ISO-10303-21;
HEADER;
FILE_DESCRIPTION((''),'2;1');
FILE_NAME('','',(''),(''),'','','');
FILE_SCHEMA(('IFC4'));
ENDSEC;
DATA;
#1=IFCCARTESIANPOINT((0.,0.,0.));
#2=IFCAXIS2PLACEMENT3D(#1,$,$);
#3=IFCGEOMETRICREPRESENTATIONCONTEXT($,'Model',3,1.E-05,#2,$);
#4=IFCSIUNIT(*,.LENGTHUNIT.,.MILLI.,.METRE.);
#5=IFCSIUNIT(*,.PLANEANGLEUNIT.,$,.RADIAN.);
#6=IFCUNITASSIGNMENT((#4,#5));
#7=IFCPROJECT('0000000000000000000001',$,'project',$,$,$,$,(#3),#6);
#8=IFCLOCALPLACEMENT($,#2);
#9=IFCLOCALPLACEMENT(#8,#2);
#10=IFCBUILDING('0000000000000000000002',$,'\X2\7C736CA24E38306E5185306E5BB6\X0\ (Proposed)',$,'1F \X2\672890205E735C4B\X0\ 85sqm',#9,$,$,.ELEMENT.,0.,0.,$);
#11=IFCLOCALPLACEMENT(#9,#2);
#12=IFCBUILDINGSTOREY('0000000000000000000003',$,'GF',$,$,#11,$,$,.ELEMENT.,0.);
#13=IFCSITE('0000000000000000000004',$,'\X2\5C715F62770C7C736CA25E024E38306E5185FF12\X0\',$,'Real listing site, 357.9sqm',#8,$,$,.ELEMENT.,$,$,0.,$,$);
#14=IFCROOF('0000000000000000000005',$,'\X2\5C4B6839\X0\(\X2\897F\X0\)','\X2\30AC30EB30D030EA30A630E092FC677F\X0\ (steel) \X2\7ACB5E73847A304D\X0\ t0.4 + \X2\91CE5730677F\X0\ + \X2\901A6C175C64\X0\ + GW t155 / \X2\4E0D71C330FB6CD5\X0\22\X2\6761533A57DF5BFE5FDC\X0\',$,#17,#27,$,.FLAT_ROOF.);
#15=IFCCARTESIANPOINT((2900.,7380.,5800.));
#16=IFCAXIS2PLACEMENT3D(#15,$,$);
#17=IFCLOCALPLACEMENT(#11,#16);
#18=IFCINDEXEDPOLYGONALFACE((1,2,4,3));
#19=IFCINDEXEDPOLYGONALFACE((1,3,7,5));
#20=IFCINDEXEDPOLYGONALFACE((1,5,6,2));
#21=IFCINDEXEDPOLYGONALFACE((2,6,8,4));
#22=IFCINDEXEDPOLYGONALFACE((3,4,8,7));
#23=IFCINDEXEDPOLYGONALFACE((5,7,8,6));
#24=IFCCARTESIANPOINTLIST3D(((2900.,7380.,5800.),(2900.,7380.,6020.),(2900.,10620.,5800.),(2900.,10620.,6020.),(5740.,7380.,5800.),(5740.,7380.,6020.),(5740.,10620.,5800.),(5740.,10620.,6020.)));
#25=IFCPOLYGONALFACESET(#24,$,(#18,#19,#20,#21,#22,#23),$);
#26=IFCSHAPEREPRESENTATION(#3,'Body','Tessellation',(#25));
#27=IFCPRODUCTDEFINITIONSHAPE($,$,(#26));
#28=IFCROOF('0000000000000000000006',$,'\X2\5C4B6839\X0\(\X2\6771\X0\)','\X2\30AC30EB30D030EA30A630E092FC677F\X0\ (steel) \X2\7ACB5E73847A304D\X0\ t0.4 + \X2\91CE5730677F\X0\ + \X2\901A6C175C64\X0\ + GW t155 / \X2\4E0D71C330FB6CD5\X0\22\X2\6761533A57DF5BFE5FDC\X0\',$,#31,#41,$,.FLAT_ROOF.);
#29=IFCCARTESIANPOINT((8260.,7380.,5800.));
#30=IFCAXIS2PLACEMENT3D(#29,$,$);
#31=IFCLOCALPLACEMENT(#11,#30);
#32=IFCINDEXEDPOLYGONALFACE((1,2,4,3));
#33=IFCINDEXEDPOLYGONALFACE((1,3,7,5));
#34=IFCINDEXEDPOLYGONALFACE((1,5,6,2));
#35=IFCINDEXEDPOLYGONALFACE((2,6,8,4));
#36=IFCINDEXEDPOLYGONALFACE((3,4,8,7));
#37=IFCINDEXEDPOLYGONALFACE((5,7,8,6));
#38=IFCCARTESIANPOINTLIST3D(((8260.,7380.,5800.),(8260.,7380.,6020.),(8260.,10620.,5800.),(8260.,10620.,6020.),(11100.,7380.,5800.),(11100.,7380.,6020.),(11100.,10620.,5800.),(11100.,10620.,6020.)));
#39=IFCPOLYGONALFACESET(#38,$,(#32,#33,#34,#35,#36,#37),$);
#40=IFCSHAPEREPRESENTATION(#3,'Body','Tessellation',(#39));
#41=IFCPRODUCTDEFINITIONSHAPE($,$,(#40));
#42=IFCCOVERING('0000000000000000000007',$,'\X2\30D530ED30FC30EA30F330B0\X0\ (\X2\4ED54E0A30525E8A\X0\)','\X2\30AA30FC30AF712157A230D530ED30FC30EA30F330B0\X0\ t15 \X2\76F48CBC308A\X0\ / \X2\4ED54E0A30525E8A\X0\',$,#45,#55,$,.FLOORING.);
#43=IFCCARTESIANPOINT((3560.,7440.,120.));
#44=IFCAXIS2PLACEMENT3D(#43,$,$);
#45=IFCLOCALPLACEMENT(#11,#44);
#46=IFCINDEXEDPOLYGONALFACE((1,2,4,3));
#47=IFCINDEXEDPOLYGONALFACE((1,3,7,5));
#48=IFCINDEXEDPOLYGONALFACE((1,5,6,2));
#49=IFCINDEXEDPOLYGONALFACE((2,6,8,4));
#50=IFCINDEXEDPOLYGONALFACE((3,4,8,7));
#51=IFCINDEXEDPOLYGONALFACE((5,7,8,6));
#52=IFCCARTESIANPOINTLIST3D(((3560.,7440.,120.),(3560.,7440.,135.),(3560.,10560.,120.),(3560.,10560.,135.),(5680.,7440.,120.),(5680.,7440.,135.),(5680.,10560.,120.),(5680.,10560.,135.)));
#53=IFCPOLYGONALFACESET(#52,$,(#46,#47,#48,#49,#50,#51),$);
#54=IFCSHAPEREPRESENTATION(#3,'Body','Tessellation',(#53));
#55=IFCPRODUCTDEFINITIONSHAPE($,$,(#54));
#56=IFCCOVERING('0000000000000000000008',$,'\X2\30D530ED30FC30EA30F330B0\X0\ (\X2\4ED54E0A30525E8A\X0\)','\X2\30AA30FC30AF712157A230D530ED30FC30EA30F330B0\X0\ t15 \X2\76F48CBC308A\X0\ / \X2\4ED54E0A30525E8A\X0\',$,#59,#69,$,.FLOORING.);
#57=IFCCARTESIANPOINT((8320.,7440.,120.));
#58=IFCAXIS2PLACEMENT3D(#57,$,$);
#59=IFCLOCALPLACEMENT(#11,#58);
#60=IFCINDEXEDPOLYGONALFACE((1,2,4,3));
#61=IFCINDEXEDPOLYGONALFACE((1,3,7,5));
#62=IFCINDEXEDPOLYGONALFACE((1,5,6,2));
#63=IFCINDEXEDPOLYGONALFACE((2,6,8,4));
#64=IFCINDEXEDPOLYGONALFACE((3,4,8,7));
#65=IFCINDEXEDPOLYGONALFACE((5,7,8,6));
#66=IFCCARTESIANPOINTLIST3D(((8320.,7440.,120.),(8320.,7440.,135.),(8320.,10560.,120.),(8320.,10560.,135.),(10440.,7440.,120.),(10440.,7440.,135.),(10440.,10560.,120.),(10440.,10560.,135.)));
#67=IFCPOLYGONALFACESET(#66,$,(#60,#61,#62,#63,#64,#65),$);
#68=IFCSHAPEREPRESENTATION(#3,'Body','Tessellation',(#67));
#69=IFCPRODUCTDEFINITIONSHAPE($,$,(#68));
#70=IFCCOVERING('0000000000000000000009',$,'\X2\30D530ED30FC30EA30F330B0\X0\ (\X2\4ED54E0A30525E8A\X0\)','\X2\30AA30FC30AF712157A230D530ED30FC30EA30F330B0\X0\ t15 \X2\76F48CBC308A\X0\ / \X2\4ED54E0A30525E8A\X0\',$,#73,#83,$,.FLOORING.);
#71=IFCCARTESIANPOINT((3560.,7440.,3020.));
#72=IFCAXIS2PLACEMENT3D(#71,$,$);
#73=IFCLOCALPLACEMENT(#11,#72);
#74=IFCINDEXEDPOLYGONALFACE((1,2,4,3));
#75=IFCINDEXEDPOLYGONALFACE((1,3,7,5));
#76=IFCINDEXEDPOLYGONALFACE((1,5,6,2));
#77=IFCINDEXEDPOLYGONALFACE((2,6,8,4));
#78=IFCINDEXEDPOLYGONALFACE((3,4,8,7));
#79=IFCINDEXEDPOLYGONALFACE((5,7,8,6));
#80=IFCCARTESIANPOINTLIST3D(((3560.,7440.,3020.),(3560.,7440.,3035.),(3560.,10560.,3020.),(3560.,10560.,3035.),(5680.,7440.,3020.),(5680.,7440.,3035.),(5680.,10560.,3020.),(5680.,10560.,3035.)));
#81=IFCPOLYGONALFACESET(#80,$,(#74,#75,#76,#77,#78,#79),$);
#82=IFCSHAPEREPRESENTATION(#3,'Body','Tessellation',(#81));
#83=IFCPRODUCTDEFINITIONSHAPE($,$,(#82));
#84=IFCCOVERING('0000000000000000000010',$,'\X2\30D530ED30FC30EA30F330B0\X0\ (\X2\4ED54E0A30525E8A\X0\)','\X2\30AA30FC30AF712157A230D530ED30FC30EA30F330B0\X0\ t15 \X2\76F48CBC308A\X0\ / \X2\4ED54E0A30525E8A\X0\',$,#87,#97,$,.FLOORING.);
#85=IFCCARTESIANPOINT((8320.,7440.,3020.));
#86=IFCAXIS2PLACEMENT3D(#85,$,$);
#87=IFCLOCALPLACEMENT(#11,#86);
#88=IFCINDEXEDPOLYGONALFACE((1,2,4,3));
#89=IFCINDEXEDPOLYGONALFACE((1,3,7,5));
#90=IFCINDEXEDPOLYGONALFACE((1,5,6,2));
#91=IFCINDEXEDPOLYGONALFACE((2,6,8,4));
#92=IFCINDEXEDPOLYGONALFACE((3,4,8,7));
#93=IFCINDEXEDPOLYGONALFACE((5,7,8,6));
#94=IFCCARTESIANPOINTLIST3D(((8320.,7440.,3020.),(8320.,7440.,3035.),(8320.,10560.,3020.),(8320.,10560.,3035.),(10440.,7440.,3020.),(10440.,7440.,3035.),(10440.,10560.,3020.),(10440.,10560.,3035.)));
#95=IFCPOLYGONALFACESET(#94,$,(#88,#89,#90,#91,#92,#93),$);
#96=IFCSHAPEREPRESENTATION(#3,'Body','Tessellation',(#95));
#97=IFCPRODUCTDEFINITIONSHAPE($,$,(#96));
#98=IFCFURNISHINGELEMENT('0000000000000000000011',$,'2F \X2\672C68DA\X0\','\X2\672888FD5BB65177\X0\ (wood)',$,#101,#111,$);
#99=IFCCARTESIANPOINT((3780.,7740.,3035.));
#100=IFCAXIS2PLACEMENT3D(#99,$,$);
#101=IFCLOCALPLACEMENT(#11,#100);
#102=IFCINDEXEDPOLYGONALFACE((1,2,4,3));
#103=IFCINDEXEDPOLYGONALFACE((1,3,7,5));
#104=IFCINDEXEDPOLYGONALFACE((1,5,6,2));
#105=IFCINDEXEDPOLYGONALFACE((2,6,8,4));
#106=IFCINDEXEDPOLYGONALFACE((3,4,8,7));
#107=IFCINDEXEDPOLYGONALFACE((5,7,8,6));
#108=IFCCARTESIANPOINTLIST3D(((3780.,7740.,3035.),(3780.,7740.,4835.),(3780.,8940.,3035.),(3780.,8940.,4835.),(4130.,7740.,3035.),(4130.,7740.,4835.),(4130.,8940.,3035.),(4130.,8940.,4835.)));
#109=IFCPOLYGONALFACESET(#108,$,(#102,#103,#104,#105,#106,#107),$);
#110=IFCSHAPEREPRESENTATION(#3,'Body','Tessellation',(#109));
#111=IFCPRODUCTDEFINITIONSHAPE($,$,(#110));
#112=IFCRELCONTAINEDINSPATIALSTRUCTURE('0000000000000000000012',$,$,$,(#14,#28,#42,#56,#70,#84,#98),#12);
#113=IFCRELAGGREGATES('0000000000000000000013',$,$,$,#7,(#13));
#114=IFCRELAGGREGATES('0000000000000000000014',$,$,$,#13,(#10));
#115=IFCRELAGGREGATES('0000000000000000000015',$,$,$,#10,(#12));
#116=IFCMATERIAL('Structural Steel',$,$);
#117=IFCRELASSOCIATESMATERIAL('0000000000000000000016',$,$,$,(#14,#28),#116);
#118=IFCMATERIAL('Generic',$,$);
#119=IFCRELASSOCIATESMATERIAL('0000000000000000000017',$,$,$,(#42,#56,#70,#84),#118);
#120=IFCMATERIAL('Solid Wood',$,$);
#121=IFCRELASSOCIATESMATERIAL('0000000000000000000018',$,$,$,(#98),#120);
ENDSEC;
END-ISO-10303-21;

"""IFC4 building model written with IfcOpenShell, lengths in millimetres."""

from ifc_helpers import new_model, si_unit, frame, frame_2d, origin, place, context, project, spatial, rectangle, extrude, material, element, save


model = new_model("IFC4")

# Units and contexts
model_context = context("Model", 3, precision=1e-05, world=origin())
ifc_project = project(units=[si_unit("LENGTHUNIT", "METRE", prefix="MILLI"), si_unit("PLANEANGLEUNIT", "RADIAN")], contexts=[model_context])

# Site, building, storey
site_placement = place(None, origin())
site = spatial("IfcSite", under=ifc_project, at=site_placement, Name="山形県米沢市丸の内２", ObjectType="Real listing site, 357.9sqm", CompositionType="ELEMENT", RefElevation=0.0)
building_placement = place(site_placement, origin())
building = spatial("IfcBuilding", under=site, at=building_placement, Name="米沢丸の内の家 (Proposed)", ObjectType="1F 木造平屋 85sqm", CompositionType="ELEMENT", ElevationOfRefHeight=0.0, ElevationOfTerrain=0.0)
storey_placement = place(building_placement, origin())
storey = spatial("IfcBuildingStorey", under=building, at=storey_placement, Name="GF", CompositionType="ELEMENT", Elevation=0.0)

# Shared definitions
ifc_material_1 = material(Name="Solid Wood")

# Shared definitions
ifc_material_2 = material(Name="Generic")

# Roofs
ifc_material_3 = material(Name="Structural Steel")
roof_1_placement = place(storey_placement, frame((2900.0, 7380.0, 5800.0)))
element("IfcRoof", 1, at=roof_1_placement, inside=storey, material=ifc_material_3, Name="屋根(西)", Description="ガルバリウム鋼板 (steel) 立平葺き t0.4 + 野地板 + 通気層 + GW t155 / 不燃・法22条区域対応", PredefinedType="FLAT_ROOF", context=model_context, shape_type="SweptSolid", body=[
    extrude(rectangle(XDim=2840.0, YDim=3240.0, at=frame_2d((1420.0, 1620.0))), frame((2900.0, 7380.0, 5800.0)), (0.0, 0.0, 1.0), 220.0),
])
roof_2_placement = place(storey_placement, frame((8260.0, 7380.0, 5800.0)))
element("IfcRoof", 2, at=roof_2_placement, inside=storey, material=ifc_material_3, Name="屋根(東)", Description="ガルバリウム鋼板 (steel) 立平葺き t0.4 + 野地板 + 通気層 + GW t155 / 不燃・法22条区域対応", PredefinedType="FLAT_ROOF", context=model_context, shape_type="SweptSolid", body=[
    extrude(rectangle(XDim=2840.0, YDim=3240.0, at=frame_2d((1420.0, 1620.0))), frame((8260.0, 7380.0, 5800.0)), (0.0, 0.0, 1.0), 220.0),
])

# Coverings
covering_1_placement = place(storey_placement, frame((3560.0, 7440.0, 120.0)))
element("IfcCovering", 3, at=covering_1_placement, inside=storey, material=ifc_material_2, Name="フローリング (仕上げ床)", Description="オーク無垢フローリング t15 直貼り / 仕上げ床", PredefinedType="FLOORING", context=model_context, shape_type="SweptSolid", body=[
    extrude(rectangle(XDim=2120.0, YDim=3120.0, at=frame_2d((1060.0, 1560.0))), frame((3560.0, 7440.0, 120.0)), (0.0, 0.0, 1.0), 15.0),
])
covering_2_placement = place(storey_placement, frame((8320.0, 7440.0, 120.0)))
element("IfcCovering", 4, at=covering_2_placement, inside=storey, material=ifc_material_2, Name="フローリング (仕上げ床)", Description="オーク無垢フローリング t15 直貼り / 仕上げ床", PredefinedType="FLOORING", context=model_context, shape_type="SweptSolid", body=[
    extrude(rectangle(XDim=2120.0, YDim=3120.0, at=frame_2d((1060.0, 1560.0))), frame((8320.0, 7440.0, 120.0)), (0.0, 0.0, 1.0), 15.0),
])
covering_3_placement = place(storey_placement, frame((3560.0, 7440.0, 3020.0)))
element("IfcCovering", 5, at=covering_3_placement, inside=storey, material=ifc_material_2, Name="フローリング (仕上げ床)", Description="オーク無垢フローリング t15 直貼り / 仕上げ床", PredefinedType="FLOORING", context=model_context, shape_type="SweptSolid", body=[
    extrude(rectangle(XDim=2120.0, YDim=3120.0, at=frame_2d((1060.0, 1560.0))), frame((3560.0, 7440.0, 3020.0)), (0.0, 0.0, 1.0), 15.0),
])
covering_4_placement = place(storey_placement, frame((8320.0, 7440.0, 3020.0)))
element("IfcCovering", 6, at=covering_4_placement, inside=storey, material=ifc_material_2, Name="フローリング (仕上げ床)", Description="オーク無垢フローリング t15 直貼り / 仕上げ床", PredefinedType="FLOORING", context=model_context, shape_type="SweptSolid", body=[
    extrude(rectangle(XDim=2120.0, YDim=3120.0, at=frame_2d((1060.0, 1560.0))), frame((8320.0, 7440.0, 3020.0)), (0.0, 0.0, 1.0), 15.0),
])

# Furnishing element
furnishing_placement = place(storey_placement, frame((3780.0, 7740.0, 3035.0)))
element("IfcFurnishingElement", 7, at=furnishing_placement, inside=storey, material=ifc_material_1, Name="2F 本棚", Description="木製家具 (wood)", context=model_context, shape_type="SweptSolid", body=[
    extrude(rectangle(XDim=350.0, YDim=1200.0, at=frame_2d((175.0, 600.0))), frame((3780.0, 7740.0, 3035.0)), (0.0, 0.0, 1.0), 1800.0),
])

save(model, "model.ifc")
